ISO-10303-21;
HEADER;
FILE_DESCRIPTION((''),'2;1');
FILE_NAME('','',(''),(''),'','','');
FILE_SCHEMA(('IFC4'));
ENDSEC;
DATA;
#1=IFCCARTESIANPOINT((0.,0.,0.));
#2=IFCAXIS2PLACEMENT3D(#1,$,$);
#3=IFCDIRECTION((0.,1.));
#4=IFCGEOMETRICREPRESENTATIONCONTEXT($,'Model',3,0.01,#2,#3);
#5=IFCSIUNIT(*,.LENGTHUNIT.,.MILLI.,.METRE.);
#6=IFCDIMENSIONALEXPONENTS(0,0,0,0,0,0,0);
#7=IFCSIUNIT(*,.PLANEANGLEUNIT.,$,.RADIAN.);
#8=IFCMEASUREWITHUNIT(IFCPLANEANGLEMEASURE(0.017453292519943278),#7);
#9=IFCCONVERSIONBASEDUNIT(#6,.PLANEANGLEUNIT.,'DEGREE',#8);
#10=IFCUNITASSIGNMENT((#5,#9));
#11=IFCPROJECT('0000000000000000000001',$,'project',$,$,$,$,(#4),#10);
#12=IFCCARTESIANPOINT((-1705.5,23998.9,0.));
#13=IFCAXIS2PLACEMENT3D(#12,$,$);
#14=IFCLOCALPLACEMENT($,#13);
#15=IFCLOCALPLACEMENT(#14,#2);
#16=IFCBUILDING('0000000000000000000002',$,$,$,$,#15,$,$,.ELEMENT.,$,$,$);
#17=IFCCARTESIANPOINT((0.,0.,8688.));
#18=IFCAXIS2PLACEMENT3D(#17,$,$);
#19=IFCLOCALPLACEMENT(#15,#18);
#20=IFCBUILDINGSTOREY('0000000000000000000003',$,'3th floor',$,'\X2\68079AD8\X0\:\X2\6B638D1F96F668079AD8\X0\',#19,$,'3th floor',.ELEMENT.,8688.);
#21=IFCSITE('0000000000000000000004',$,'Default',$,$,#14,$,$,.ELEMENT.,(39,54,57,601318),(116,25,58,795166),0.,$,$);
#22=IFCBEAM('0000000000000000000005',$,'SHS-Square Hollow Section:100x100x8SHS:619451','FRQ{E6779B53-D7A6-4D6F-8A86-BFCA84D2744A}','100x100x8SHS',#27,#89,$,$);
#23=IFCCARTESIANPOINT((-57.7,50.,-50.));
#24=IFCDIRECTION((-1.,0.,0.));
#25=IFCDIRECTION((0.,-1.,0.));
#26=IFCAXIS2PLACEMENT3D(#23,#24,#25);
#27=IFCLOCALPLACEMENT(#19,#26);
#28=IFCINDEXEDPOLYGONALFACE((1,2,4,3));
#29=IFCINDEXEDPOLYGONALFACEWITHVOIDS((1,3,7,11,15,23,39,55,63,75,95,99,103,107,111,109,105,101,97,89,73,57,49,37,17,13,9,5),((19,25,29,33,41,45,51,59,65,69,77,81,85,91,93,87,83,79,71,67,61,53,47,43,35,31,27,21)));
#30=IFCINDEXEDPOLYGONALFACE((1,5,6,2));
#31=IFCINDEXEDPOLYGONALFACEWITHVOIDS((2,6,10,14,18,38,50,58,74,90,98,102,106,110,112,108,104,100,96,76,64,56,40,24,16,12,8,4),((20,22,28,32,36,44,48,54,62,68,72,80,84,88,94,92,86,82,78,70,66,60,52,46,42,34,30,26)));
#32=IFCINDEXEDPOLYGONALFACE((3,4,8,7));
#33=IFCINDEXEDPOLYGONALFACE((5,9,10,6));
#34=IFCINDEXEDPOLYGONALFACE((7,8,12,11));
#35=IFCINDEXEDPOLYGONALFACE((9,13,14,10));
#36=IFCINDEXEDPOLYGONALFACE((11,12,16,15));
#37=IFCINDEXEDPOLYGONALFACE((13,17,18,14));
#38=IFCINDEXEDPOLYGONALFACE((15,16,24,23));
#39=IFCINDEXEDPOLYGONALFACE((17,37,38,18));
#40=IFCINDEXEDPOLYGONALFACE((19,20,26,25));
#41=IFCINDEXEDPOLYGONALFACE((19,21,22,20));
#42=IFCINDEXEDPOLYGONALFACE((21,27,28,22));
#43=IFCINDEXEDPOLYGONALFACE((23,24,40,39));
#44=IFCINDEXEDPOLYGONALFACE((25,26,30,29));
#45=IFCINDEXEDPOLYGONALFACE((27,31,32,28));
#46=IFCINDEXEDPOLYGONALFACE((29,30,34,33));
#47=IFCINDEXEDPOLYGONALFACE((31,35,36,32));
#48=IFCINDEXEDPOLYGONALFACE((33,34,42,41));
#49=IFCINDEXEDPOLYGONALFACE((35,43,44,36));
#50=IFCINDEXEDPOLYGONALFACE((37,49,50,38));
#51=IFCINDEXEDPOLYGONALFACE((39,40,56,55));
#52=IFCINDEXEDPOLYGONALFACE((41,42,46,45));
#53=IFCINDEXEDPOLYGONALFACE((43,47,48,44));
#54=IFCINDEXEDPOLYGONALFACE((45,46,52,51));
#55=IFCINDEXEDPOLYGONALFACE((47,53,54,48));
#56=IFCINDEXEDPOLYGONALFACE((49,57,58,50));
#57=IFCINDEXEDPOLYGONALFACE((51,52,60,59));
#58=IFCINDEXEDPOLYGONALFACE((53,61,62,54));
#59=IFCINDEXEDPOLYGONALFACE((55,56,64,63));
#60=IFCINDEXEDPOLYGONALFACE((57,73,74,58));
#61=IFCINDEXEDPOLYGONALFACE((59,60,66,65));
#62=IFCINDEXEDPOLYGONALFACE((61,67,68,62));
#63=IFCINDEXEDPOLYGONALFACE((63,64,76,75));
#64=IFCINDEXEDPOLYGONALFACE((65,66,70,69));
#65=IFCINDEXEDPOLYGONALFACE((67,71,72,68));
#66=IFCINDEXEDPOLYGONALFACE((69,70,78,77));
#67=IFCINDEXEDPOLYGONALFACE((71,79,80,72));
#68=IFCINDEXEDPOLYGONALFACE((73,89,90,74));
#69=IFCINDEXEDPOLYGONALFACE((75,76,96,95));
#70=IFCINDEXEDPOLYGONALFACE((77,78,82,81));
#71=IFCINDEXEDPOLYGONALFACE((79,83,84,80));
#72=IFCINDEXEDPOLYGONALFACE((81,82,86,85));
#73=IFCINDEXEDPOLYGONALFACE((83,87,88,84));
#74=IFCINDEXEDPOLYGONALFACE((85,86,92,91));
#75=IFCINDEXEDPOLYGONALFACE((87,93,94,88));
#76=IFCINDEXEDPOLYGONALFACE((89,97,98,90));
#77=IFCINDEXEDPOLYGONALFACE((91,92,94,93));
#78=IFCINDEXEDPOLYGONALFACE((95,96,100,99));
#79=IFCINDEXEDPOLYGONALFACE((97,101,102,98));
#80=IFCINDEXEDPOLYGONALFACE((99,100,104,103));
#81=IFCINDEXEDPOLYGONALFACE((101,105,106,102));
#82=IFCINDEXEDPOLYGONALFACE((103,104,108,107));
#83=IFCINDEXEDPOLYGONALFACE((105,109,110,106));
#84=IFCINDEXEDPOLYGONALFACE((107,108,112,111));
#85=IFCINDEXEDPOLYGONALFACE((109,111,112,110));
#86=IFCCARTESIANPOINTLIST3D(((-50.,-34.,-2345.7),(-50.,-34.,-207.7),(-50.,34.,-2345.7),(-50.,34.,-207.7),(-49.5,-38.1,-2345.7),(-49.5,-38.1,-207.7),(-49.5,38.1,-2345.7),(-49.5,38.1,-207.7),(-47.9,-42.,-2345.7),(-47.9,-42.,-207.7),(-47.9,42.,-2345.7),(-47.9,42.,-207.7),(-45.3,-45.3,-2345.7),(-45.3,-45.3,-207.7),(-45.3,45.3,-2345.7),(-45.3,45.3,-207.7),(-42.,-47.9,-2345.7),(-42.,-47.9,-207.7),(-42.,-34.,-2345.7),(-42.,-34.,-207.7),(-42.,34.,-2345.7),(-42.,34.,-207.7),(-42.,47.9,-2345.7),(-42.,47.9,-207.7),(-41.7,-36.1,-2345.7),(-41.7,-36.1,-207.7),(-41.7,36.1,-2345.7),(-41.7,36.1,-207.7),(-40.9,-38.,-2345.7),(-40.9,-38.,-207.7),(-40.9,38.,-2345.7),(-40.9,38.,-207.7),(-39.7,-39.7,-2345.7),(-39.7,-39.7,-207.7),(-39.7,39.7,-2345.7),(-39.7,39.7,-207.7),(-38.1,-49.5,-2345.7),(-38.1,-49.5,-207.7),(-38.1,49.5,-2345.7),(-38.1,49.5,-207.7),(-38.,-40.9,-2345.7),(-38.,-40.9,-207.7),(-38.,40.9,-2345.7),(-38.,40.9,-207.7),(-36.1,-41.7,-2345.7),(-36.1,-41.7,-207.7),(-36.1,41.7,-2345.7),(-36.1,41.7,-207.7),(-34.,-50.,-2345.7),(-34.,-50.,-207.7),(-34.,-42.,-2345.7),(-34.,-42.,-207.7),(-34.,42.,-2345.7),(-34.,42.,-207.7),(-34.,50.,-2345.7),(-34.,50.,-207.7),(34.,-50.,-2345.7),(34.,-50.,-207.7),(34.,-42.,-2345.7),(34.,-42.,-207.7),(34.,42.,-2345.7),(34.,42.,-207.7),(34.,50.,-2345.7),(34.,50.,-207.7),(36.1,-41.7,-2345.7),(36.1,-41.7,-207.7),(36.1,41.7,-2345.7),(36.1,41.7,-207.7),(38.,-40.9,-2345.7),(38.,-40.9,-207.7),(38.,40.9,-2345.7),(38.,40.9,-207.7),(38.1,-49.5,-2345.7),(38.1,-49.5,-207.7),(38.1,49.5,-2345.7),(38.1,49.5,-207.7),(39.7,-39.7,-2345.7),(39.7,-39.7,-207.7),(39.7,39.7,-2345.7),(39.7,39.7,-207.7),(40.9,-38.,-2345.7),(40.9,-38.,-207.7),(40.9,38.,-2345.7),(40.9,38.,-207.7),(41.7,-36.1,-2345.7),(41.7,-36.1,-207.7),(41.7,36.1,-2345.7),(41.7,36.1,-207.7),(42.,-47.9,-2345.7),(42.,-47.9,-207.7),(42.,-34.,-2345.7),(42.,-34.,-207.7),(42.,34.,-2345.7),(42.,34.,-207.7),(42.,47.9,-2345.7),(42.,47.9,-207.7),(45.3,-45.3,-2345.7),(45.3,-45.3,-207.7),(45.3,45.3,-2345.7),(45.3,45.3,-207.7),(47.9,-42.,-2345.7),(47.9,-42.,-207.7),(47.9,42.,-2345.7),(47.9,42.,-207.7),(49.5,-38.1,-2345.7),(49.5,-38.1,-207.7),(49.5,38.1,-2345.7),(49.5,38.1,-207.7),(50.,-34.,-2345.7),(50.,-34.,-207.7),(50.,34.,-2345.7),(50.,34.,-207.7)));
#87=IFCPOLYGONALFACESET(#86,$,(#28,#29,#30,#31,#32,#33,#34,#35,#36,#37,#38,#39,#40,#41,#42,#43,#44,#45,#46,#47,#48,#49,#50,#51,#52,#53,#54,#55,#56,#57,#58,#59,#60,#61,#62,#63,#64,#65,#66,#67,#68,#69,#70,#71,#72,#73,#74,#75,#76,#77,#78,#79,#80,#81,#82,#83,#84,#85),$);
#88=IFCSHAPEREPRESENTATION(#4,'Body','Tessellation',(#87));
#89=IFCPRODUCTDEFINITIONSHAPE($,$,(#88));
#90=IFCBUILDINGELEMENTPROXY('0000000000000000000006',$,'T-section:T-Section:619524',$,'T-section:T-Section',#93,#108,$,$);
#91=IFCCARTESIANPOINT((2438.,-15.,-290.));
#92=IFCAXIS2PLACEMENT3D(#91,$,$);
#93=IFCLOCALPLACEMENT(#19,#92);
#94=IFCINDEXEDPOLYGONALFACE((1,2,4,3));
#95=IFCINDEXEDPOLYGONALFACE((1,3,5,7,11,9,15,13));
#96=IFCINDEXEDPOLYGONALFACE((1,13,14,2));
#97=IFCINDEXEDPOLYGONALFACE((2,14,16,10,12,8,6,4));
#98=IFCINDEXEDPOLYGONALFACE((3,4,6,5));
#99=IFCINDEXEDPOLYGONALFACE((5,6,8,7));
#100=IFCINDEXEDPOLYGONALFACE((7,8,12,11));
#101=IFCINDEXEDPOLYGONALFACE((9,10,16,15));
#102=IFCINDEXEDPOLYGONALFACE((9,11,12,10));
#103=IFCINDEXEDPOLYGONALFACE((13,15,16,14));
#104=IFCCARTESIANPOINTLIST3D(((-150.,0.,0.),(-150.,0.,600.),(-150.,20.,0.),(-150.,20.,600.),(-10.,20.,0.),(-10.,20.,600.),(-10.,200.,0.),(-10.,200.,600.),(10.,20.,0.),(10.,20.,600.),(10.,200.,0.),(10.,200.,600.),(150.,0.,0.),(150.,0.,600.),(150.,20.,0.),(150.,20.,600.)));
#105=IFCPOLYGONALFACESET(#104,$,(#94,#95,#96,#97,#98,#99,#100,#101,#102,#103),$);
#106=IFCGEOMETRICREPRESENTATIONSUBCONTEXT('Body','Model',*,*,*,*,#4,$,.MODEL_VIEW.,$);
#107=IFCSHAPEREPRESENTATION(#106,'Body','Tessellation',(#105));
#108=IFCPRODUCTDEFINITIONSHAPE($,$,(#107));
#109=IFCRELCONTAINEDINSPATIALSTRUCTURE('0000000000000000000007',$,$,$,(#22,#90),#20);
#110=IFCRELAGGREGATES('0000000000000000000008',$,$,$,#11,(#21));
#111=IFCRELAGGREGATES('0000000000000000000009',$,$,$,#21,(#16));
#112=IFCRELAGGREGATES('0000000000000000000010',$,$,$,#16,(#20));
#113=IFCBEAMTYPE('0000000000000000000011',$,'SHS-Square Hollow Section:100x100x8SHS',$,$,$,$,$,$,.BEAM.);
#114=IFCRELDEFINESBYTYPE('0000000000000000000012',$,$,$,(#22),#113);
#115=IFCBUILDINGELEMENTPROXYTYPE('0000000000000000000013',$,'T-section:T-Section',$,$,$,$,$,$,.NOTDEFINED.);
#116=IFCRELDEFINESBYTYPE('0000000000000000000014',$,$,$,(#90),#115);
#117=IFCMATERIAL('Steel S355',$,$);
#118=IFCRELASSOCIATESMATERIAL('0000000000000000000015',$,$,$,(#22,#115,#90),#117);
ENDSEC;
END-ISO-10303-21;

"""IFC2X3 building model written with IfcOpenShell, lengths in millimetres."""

from ifc_helpers import new_model, entity, si_unit, converted_unit, direction, frame, origin, origin_2d, place, context, subcontext, project, spatial, polyline, hollow_rectangle, outline, extrude, clip, halfspace, source, transform, mapped, material, type_object, type_shapes, element, save


model = new_model("IFC2X3")

# Units and contexts
model_context = context("Model", 3, precision=0.01, world=origin(), true_north=direction((0.0, 1.0)))
body_context = subcontext(model_context, "Body", "Model", "MODEL_VIEW")
ifc_project = project(units=[si_unit("LENGTHUNIT", "METRE", prefix="MILLI"), converted_unit("PLANEANGLEUNIT", "DEGREE", entity("IfcPlaneAngleMeasure", 0.017453292519943278), si_unit("PLANEANGLEUNIT", "RADIAN"), dimensions=[0, 0, 0, 0, 0, 0, 0])], contexts=[model_context])

# Site, building, storey
site_placement = place(None, frame((-1705.5, 23998.9, 0.0)))
site = spatial("IfcSite", under=ifc_project, at=site_placement, Name="Default", CompositionType="ELEMENT", RefLatitude=(39, 54, 57, 601318), RefLongitude=(116, 25, 58, 795166), RefElevation=0.0)
building_placement = place(site_placement, origin())
building = spatial("IfcBuilding", under=site, at=building_placement, CompositionType="ELEMENT")
storey_placement = place(building_placement, frame((0.0, 0.0, 8688.0)))
storey = spatial("IfcBuildingStorey", under=building, at=storey_placement, Name="3th floor", ObjectType="标高:正负零标高", LongName="3th floor", CompositionType="ELEMENT", Elevation=8688.0)

# Beam
ifc_material_1 = material(Name="Steel S355")
beam_type_1 = type_object("IfcBeamType", Name="SHS-Square Hollow Section:100x100x8SHS", PredefinedType="BEAM")
beam_1_placement = place(storey_placement, frame((-57.7, 50.0, -50.0), z_axis=(-1.0, 0.0, 0.0), x_axis=(0.0, -1.0, 0.0)))
element("IfcBeam", 1, at=beam_1_placement, inside=storey, type_object=beam_type_1, material=ifc_material_1, Name="SHS-Square Hollow Section:100x100x8SHS:619451", Description="FRQ{E6779B53-D7A6-4D6F-8A86-BFCA84D2744A}", ObjectType="100x100x8SHS", context=model_context, shape_type="Clipping", body=[
    clip(clip(extrude(hollow_rectangle(XDim=100.0, YDim=100.0, WallThickness=8.0, InnerFilletRadius=8.0, OuterFilletRadius=16.0, at=origin_2d()), origin(), (0.0, 0.0, -1.0), 2551.4), halfspace(frame((50.0, -8638.0, -2345.7), z_axis=(0.0, 0.0, 1.0), x_axis=(1.0, 0.0, 0.0)), True)), halfspace(frame((50.0, -8638.0, -207.7), z_axis=(0.0, 0.0, -1.0), x_axis=(-1.0, 0.0, 0.0)), True)),
])

# Building element proxy
building_element_proxy_type_1 = type_object("IfcBuildingElementProxyType", Name="T-section:T-Section", PredefinedType="NOTDEFINED", material=ifc_material_1)
shared_shape_1 = source(origin(), body_context, "Body", "SweptSolid", [
    extrude(outline(polyline([(-140.0, 10.0), (-140.0, -10.0), (40.0, -10.0), (40.0, -150.0), (60.0, -150.0), (60.0, 150.0), (40.0, 150.0), (40.0, 10.0), (-140.0, 10.0)])), frame((0.0, 60.0, 0.0), z_axis=(0.0, 0.0, -1.0), x_axis=(0.0, -1.0, 0.0)), (0.0, 0.0, -1.0), 600.0),
])
type_shapes(building_element_proxy_type_1, [shared_shape_1])
proxy_1_placement = place(storey_placement, frame((2438.0, -15.0, -290.0)))
element("IfcBuildingElementProxy", 2, at=proxy_1_placement, inside=storey, type_object=building_element_proxy_type_1, material=ifc_material_1, Name="T-section:T-Section:619524", ObjectType="T-section:T-Section", context=body_context, shape_type="MappedRepresentation", body=[
    mapped(shared_shape_1, transform((0.0, 0.0, 0.0), scale=1.0)),
])

save(model, "model.ifc")
